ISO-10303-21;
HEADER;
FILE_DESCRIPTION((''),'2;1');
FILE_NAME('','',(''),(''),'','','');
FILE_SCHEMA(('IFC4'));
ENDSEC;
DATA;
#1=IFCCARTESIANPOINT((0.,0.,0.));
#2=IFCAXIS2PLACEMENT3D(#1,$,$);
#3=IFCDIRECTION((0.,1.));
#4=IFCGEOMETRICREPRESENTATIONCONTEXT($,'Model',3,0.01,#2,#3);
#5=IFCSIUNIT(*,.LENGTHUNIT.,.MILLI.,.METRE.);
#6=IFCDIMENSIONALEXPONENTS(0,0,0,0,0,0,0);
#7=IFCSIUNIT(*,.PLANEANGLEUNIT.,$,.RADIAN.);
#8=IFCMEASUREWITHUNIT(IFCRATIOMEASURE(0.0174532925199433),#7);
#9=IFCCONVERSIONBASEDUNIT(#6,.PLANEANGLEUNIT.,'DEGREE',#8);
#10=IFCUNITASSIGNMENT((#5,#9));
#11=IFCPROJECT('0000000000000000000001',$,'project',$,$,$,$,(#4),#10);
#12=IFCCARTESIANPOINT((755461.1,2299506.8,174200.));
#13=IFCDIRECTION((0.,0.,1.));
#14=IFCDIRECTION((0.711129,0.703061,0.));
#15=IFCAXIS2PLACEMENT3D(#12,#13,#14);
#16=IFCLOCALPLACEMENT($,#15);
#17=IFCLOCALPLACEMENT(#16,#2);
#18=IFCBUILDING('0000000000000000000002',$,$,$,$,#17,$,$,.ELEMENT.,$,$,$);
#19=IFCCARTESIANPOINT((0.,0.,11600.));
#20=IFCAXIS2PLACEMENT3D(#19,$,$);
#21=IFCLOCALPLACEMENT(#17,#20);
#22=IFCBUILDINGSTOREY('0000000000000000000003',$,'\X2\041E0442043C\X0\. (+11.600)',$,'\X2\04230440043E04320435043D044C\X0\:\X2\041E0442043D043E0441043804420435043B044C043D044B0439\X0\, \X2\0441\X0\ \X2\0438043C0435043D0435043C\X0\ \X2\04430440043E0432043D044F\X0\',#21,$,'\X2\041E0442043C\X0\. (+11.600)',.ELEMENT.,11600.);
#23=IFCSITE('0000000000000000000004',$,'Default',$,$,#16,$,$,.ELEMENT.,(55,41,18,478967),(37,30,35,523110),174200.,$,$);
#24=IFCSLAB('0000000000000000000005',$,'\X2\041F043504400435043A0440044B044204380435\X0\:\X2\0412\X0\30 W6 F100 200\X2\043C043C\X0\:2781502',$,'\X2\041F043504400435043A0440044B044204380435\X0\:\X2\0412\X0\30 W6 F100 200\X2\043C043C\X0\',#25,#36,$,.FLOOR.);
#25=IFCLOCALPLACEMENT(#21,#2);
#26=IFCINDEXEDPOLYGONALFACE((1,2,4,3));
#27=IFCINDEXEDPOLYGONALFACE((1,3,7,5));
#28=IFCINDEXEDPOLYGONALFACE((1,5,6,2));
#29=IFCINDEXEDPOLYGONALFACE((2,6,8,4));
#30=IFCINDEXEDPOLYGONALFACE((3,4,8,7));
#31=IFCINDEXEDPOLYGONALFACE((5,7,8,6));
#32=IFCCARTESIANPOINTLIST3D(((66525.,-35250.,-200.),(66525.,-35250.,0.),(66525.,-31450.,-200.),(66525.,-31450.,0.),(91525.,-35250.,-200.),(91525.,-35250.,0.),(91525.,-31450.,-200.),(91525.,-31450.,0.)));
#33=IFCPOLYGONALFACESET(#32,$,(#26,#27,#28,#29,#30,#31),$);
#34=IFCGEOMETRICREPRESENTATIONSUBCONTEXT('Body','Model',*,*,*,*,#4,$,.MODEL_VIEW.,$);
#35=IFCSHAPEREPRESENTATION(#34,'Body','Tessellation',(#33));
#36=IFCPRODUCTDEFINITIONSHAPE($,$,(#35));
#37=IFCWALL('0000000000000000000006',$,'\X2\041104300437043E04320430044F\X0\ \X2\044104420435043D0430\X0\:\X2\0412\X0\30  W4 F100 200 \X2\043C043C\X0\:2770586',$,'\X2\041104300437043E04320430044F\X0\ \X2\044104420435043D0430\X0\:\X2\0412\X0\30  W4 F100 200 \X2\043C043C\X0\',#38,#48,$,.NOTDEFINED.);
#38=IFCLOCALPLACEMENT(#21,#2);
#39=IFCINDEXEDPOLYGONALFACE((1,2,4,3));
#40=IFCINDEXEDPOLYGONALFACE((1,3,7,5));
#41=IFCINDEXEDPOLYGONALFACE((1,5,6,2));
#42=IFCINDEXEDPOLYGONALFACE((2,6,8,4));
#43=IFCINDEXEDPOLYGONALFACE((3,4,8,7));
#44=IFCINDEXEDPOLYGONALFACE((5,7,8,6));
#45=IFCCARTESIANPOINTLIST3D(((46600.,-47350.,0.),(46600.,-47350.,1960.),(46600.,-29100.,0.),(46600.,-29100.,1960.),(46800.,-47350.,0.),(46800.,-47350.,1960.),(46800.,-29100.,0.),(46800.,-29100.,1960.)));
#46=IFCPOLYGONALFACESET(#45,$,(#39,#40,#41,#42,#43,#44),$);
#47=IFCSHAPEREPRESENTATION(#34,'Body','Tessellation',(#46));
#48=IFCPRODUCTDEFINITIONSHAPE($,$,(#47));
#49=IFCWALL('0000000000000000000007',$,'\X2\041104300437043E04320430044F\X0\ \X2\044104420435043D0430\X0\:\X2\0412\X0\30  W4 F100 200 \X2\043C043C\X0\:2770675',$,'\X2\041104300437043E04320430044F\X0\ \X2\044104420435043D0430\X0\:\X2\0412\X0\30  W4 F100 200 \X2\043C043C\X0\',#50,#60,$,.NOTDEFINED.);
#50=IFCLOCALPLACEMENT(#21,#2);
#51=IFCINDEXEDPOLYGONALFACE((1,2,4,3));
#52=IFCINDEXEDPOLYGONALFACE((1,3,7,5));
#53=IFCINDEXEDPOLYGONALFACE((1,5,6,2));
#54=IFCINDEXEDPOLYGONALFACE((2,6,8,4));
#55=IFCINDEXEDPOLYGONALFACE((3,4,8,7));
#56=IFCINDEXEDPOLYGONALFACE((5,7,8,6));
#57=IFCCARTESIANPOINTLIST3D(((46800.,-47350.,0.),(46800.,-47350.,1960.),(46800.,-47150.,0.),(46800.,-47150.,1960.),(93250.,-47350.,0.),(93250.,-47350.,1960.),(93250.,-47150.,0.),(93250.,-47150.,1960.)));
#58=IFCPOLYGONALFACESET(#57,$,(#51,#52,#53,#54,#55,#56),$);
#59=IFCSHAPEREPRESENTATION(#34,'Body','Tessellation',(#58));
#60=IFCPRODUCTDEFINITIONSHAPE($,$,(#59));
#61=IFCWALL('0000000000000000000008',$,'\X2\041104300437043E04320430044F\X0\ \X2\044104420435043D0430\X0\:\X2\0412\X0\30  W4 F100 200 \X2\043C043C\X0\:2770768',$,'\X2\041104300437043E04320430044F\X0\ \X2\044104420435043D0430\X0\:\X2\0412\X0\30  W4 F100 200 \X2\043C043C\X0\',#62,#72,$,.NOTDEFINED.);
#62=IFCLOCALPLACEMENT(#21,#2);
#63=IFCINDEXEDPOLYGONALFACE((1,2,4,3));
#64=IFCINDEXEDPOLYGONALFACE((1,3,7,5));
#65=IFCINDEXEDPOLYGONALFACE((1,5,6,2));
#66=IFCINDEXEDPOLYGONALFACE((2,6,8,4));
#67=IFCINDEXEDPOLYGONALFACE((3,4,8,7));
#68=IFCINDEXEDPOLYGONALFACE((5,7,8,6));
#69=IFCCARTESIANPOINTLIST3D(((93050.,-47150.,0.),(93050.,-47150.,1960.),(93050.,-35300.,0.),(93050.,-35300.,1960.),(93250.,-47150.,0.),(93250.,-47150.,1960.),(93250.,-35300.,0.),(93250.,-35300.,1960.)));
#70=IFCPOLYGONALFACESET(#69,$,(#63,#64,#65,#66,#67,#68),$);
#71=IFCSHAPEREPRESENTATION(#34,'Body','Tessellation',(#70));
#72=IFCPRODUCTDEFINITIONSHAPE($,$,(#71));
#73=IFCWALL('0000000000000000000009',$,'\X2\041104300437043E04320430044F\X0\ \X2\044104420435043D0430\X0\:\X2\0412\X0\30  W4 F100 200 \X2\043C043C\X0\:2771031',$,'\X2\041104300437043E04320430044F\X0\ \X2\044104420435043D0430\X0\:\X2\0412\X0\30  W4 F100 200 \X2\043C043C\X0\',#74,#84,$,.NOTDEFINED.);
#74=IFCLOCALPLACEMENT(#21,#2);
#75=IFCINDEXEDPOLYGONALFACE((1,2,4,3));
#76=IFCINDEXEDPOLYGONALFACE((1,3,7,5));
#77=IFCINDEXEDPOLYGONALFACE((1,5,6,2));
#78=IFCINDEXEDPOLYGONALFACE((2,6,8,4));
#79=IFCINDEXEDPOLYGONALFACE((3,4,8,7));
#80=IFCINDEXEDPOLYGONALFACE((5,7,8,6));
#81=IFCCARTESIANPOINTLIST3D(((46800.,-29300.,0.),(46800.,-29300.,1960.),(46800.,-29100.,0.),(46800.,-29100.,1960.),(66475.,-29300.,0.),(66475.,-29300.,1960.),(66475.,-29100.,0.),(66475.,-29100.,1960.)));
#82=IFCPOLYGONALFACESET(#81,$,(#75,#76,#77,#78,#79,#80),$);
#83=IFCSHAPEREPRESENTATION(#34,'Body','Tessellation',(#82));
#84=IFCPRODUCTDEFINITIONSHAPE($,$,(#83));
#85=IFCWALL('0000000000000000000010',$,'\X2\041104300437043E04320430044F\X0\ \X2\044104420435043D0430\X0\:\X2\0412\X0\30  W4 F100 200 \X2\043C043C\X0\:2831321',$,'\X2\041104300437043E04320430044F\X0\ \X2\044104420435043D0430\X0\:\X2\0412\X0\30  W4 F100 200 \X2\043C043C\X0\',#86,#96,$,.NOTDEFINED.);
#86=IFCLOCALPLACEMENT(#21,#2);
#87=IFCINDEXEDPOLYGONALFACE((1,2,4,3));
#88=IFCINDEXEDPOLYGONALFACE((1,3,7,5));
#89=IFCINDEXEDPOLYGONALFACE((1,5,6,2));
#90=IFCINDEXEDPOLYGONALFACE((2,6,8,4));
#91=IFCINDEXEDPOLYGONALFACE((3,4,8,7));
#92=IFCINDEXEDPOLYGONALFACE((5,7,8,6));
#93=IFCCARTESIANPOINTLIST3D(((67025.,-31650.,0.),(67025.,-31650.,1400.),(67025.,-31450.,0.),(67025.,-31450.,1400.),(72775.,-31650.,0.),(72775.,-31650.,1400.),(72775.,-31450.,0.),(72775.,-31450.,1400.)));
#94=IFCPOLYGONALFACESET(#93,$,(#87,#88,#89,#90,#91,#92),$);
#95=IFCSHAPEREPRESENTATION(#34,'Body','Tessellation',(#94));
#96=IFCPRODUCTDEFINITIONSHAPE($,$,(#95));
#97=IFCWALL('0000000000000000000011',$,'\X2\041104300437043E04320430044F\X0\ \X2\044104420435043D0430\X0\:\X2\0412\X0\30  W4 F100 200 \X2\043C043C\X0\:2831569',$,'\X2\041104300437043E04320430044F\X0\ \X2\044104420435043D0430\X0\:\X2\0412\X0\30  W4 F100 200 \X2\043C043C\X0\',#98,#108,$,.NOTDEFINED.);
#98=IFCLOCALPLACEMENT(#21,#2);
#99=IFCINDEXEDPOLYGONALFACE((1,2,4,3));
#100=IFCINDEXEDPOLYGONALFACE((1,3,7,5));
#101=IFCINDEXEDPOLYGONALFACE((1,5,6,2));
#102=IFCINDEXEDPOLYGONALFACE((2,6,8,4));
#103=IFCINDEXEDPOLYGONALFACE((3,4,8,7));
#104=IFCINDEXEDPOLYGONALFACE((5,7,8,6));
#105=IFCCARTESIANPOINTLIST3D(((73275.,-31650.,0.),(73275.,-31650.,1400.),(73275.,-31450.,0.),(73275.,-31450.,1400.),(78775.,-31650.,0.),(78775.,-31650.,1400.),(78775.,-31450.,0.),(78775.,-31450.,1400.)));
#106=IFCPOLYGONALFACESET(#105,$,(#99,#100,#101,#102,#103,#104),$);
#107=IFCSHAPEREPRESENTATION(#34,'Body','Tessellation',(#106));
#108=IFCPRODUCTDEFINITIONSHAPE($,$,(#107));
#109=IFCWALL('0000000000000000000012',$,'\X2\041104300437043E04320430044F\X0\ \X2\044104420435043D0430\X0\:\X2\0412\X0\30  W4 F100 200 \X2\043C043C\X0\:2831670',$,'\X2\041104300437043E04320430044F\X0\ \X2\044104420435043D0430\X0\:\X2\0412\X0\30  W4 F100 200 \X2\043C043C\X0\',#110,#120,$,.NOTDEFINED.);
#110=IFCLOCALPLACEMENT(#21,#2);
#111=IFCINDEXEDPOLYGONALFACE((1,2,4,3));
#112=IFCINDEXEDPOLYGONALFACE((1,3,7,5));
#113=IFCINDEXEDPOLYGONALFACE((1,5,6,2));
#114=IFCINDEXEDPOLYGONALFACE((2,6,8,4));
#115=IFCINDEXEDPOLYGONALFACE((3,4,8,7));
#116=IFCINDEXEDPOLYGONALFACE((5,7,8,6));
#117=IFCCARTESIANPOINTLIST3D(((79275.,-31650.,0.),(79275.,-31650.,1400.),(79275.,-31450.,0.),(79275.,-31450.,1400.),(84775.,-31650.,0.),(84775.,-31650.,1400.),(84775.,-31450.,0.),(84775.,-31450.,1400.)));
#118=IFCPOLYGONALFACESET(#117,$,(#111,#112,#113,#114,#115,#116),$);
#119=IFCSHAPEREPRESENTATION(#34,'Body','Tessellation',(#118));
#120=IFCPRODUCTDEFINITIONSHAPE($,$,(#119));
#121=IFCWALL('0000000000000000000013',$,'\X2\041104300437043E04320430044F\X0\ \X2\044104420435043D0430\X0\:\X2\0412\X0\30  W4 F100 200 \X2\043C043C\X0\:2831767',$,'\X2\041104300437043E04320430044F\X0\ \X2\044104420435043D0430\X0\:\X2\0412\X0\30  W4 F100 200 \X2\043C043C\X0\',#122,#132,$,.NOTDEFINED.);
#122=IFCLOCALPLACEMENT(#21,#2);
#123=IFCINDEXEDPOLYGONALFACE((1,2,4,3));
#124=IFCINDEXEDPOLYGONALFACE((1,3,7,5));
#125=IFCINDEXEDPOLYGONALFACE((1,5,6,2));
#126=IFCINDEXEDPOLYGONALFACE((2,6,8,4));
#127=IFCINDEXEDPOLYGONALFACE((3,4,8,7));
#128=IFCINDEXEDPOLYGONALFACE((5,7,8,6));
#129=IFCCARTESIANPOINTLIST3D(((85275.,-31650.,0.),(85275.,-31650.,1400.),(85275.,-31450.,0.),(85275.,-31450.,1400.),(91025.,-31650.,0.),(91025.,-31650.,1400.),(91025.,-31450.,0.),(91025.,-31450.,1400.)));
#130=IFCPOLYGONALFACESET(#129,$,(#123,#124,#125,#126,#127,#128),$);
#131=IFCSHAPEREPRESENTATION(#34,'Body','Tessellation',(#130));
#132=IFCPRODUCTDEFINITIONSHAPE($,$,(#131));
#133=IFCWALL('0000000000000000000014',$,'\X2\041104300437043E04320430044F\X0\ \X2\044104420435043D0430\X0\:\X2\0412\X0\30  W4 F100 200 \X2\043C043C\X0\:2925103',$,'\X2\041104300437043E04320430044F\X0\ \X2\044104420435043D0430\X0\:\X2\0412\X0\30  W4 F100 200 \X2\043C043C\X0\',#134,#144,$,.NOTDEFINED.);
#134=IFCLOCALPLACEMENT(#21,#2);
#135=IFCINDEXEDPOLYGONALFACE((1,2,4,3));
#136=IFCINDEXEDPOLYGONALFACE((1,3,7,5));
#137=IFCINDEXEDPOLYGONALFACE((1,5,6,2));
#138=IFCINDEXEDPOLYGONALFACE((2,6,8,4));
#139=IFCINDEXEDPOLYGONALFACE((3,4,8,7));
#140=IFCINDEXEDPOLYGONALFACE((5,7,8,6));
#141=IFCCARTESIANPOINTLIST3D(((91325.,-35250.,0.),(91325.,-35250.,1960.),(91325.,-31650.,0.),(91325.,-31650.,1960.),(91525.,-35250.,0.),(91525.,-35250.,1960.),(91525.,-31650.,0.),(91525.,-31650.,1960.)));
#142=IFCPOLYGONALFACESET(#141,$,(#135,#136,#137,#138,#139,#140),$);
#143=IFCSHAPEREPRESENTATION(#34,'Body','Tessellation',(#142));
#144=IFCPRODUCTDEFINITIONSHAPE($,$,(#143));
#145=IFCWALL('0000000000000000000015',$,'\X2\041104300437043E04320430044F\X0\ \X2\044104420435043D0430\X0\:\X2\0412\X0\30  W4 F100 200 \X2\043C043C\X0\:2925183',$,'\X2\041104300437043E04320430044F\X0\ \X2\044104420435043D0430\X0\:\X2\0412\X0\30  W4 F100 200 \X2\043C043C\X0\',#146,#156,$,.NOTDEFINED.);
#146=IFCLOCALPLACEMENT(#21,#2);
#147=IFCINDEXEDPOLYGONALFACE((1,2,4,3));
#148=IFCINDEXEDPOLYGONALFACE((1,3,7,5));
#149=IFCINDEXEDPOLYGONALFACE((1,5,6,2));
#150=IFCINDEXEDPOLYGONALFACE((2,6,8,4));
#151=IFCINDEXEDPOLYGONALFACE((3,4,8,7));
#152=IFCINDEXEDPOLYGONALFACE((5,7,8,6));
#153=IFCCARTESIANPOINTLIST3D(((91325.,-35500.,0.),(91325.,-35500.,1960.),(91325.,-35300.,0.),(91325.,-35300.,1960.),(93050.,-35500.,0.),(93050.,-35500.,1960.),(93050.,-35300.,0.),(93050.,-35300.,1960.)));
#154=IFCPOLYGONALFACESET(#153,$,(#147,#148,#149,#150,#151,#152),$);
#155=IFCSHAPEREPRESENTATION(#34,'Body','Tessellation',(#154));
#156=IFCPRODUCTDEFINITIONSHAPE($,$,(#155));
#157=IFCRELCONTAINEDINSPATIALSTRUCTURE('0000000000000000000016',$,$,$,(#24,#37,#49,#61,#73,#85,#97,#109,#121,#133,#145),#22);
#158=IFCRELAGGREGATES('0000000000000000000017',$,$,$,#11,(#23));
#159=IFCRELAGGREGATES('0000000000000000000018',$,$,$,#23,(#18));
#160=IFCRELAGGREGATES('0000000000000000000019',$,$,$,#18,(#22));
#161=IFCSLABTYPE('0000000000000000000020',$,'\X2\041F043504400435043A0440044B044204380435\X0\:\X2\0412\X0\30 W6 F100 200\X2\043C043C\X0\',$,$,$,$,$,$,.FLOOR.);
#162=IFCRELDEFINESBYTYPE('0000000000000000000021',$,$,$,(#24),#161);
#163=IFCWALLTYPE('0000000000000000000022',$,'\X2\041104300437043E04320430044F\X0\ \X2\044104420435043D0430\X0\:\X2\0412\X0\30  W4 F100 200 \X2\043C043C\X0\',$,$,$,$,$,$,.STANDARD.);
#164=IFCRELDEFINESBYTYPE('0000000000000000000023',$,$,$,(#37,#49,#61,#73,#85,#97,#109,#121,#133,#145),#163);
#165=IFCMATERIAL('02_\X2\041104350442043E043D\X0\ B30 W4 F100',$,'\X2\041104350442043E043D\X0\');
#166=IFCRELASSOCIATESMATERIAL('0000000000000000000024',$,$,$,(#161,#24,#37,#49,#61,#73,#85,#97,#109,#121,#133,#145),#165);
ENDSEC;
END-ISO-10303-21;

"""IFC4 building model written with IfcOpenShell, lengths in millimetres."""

from ifc_helpers import new_model, entity, si_unit, converted_unit, direction, frame, origin, place, context, subcontext, project, spatial, indexed_curve, outline, extrude, material, type_object, element, save


model = new_model("IFC4")

# Units and contexts
model_context = context("Model", 3, precision=0.01, world=origin(), true_north=direction((0.0, 1.0)))
body_context = subcontext(model_context, "Body", "Model", "MODEL_VIEW")
ifc_project = project(units=[si_unit("LENGTHUNIT", "METRE", prefix="MILLI"), converted_unit("PLANEANGLEUNIT", "DEGREE", entity("IfcRatioMeasure", 0.0174532925199433), si_unit("PLANEANGLEUNIT", "RADIAN"), dimensions=[0, 0, 0, 0, 0, 0, 0])], contexts=[model_context])

# Site, building, storey
site_placement = place(None, frame((755461.1, 2299506.8, 174200.0), z_axis=(0.0, 0.0, 1.0), x_axis=(0.711129, 0.703061, 0.0)))
site = spatial("IfcSite", under=ifc_project, at=site_placement, Name="Default", CompositionType="ELEMENT", RefLatitude=(55, 41, 18, 478967), RefLongitude=(37, 30, 35, 523110), RefElevation=174200.0)
building_placement = place(site_placement, origin())
building = spatial("IfcBuilding", under=site, at=building_placement, CompositionType="ELEMENT")
storey_placement = place(building_placement, frame((0.0, 0.0, 11600.0)))
storey = spatial("IfcBuildingStorey", under=building, at=storey_placement, Name="Отм. (+11.600)", ObjectType="Уровень:Относительный, с именем уровня", LongName="Отм. (+11.600)", CompositionType="ELEMENT", Elevation=11600.0)

# Slab
ifc_material_1 = material(Name="02_Бетон B30 W4 F100", Category="Бетон")
slab_type_1 = type_object("IfcSlabType", Name="Перекрытие:В30 W6 F100 200мм", PredefinedType="FLOOR", material=ifc_material_1)
slab_1_placement = place(storey_placement, origin())
element("IfcSlab", 1, at=slab_1_placement, inside=storey, type_object=slab_type_1, material=ifc_material_1, Name="Перекрытие:В30 W6 F100 200мм:2781502", ObjectType="Перекрытие:В30 W6 F100 200мм", PredefinedType="FLOOR", context=body_context, shape_type="SweptSolid", body=[
    extrude(outline(indexed_curve([(-1900.0, -12500.0), (1900.0, -12500.0), (1900.0, 12500.0), (-1900.0, 12500.0), (-1900.0, -12500.0)], self_intersect=False)), frame((79025.0, -33350.0, 0.0), z_axis=(0.0, 0.0, -1.0), x_axis=(0.0, 1.0, 0.0)), (0.0, 0.0, 1.0), 200.0),
])

# Walls
wall_type = type_object("IfcWallType", Name="Базовая стена:В30  W4 F100 200 мм", PredefinedType="STANDARD")
wall_1_placement = place(storey_placement, frame((46700.0, -29100.0, 0.0), z_axis=(0.0, 0.0, 1.0), x_axis=(0.0, -1.0, 0.0)))
element("IfcWall", 2, at=wall_1_placement, inside=storey, type_object=wall_type, material=ifc_material_1, Name="Базовая стена:В30  W4 F100 200 мм:2770586", ObjectType="Базовая стена:В30  W4 F100 200 мм", PredefinedType="NOTDEFINED", context=body_context, shape_type="SweptSolid", body=[
    extrude(outline(indexed_curve([(18250.0, 100.0), (0.0, 100.0), (0.0, -100.0), (18250.0, -100.0), (18250.0, 100.0)], self_intersect=False)), origin(), (0.0, 0.0, 1.0), 1960.0),
])
wall_2_placement = place(storey_placement, frame((46800.0, -47250.0, 0.0)))
element("IfcWall", 3, at=wall_2_placement, inside=storey, type_object=wall_type, material=ifc_material_1, Name="Базовая стена:В30  W4 F100 200 мм:2770675", ObjectType="Базовая стена:В30  W4 F100 200 мм", PredefinedType="NOTDEFINED", context=body_context, shape_type="SweptSolid", body=[
    extrude(outline(indexed_curve([(46450.0, 100.0), (0.0, 100.0), (0.0, -100.0), (46450.0, -100.0), (46450.0, 100.0)], self_intersect=False)), origin(), (0.0, 0.0, 1.0), 1960.0),
])
wall_3_placement = place(storey_placement, frame((93150.0, -47150.0, 0.0), z_axis=(0.0, 0.0, 1.0), x_axis=(0.0, 1.0, 0.0)))
element("IfcWall", 4, at=wall_3_placement, inside=storey, type_object=wall_type, material=ifc_material_1, Name="Базовая стена:В30  W4 F100 200 мм:2770768", ObjectType="Базовая стена:В30  W4 F100 200 мм", PredefinedType="NOTDEFINED", context=body_context, shape_type="SweptSolid", body=[
    extrude(outline(indexed_curve([(11850.0, 100.0), (0.0, 100.0), (0.0, -100.0), (11850.0, -100.0), (11850.0, 100.0)], self_intersect=False)), origin(), (0.0, 0.0, 1.0), 1960.0),
])
wall_4_placement = place(storey_placement, frame((66475.0, -29200.0, 0.0), z_axis=(0.0, 0.0, 1.0), x_axis=(-1.0, 0.0, 0.0)))
element("IfcWall", 5, at=wall_4_placement, inside=storey, type_object=wall_type, material=ifc_material_1, Name="Базовая стена:В30  W4 F100 200 мм:2771031", ObjectType="Базовая стена:В30  W4 F100 200 мм", PredefinedType="NOTDEFINED", context=body_context, shape_type="SweptSolid", body=[
    extrude(outline(indexed_curve([(19675.0, 100.0), (0.0, 100.0), (0.0, -100.0), (19675.0, -100.0), (19675.0, 100.0)], self_intersect=False)), origin(), (0.0, 0.0, 1.0), 1960.0),
])
wall_5_placement = place(storey_placement, frame((67025.0, -31550.0, 0.0)))
element("IfcWall", 6, at=wall_5_placement, inside=storey, type_object=wall_type, material=ifc_material_1, Name="Базовая стена:В30  W4 F100 200 мм:2831321", ObjectType="Базовая стена:В30  W4 F100 200 мм", PredefinedType="NOTDEFINED", context=body_context, shape_type="SweptSolid", body=[
    extrude(outline(indexed_curve([(5750.0, 100.0), (0.0, 100.0), (0.0, -100.0), (5750.0, -100.0), (5750.0, 100.0)], self_intersect=False)), origin(), (0.0, 0.0, 1.0), 1400.0),
])
wall_6_placement = place(storey_placement, frame((73275.0, -31550.0, 0.0)))
element("IfcWall", 7, at=wall_6_placement, inside=storey, type_object=wall_type, material=ifc_material_1, Name="Базовая стена:В30  W4 F100 200 мм:2831569", ObjectType="Базовая стена:В30  W4 F100 200 мм", PredefinedType="NOTDEFINED", context=body_context, shape_type="SweptSolid", body=[
    extrude(outline(indexed_curve([(5500.0, 100.0), (0.0, 100.0), (0.0, -100.0), (5500.0, -100.0), (5500.0, 100.0)], self_intersect=False)), origin(), (0.0, 0.0, 1.0), 1400.0),
])
wall_7_placement = place(storey_placement, frame((79275.0, -31550.0, 0.0)))
element("IfcWall", 8, at=wall_7_placement, inside=storey, type_object=wall_type, material=ifc_material_1, Name="Базовая стена:В30  W4 F100 200 мм:2831670", ObjectType="Базовая стена:В30  W4 F100 200 мм", PredefinedType="NOTDEFINED", context=body_context, shape_type="SweptSolid", body=[
    extrude(outline(indexed_curve([(5500.0, 100.0), (0.0, 100.0), (0.0, -100.0), (5500.0, -100.0), (5500.0, 100.0)], self_intersect=False)), origin(), (0.0, 0.0, 1.0), 1400.0),
])
wall_8_placement = place(storey_placement, frame((85275.0, -31550.0, 0.0)))
element("IfcWall", 9, at=wall_8_placement, inside=storey, type_object=wall_type, material=ifc_material_1, Name="Базовая стена:В30  W4 F100 200 мм:2831767", ObjectType="Базовая стена:В30  W4 F100 200 мм", PredefinedType="NOTDEFINED", context=body_context, shape_type="SweptSolid", body=[
    extrude(outline(indexed_curve([(5750.0, 100.0), (0.0, 100.0), (0.0, -100.0), (5750.0, -100.0), (5750.0, 100.0)], self_intersect=False)), origin(), (0.0, 0.0, 1.0), 1400.0),
])
wall_9_placement = place(storey_placement, frame((91425.0, -31650.0, 0.0), z_axis=(0.0, 0.0, 1.0), x_axis=(0.0, -1.0, 0.0)))
element("IfcWall", 10, at=wall_9_placement, inside=storey, type_object=wall_type, material=ifc_material_1, Name="Базовая стена:В30  W4 F100 200 мм:2925103", ObjectType="Базовая стена:В30  W4 F100 200 мм", PredefinedType="NOTDEFINED", context=body_context, shape_type="SweptSolid", body=[
    extrude(outline(indexed_curve([(3600.0, 100.0), (0.0, 100.0), (0.0, -100.0), (3600.0, -100.0), (3600.0, 100.0)], self_intersect=False)), origin(), (0.0, 0.0, 1.0), 1960.0),
])
wall_10_placement = place(storey_placement, frame((93050.0, -35400.0, 0.0), z_axis=(0.0, 0.0, 1.0), x_axis=(-1.0, 0.0, 0.0)))
element("IfcWall", 11, at=wall_10_placement, inside=storey, type_object=wall_type, material=ifc_material_1, Name="Базовая стена:В30  W4 F100 200 мм:2925183", ObjectType="Базовая стена:В30  W4 F100 200 мм", PredefinedType="NOTDEFINED", context=body_context, shape_type="SweptSolid", body=[
    extrude(outline(indexed_curve([(1725.0, 100.0), (0.0, 100.0), (0.0, -100.0), (1725.0, -100.0), (1725.0, 100.0)], self_intersect=False)), origin(), (0.0, 0.0, 1.0), 1960.0),
])

save(model, "model.ifc")
